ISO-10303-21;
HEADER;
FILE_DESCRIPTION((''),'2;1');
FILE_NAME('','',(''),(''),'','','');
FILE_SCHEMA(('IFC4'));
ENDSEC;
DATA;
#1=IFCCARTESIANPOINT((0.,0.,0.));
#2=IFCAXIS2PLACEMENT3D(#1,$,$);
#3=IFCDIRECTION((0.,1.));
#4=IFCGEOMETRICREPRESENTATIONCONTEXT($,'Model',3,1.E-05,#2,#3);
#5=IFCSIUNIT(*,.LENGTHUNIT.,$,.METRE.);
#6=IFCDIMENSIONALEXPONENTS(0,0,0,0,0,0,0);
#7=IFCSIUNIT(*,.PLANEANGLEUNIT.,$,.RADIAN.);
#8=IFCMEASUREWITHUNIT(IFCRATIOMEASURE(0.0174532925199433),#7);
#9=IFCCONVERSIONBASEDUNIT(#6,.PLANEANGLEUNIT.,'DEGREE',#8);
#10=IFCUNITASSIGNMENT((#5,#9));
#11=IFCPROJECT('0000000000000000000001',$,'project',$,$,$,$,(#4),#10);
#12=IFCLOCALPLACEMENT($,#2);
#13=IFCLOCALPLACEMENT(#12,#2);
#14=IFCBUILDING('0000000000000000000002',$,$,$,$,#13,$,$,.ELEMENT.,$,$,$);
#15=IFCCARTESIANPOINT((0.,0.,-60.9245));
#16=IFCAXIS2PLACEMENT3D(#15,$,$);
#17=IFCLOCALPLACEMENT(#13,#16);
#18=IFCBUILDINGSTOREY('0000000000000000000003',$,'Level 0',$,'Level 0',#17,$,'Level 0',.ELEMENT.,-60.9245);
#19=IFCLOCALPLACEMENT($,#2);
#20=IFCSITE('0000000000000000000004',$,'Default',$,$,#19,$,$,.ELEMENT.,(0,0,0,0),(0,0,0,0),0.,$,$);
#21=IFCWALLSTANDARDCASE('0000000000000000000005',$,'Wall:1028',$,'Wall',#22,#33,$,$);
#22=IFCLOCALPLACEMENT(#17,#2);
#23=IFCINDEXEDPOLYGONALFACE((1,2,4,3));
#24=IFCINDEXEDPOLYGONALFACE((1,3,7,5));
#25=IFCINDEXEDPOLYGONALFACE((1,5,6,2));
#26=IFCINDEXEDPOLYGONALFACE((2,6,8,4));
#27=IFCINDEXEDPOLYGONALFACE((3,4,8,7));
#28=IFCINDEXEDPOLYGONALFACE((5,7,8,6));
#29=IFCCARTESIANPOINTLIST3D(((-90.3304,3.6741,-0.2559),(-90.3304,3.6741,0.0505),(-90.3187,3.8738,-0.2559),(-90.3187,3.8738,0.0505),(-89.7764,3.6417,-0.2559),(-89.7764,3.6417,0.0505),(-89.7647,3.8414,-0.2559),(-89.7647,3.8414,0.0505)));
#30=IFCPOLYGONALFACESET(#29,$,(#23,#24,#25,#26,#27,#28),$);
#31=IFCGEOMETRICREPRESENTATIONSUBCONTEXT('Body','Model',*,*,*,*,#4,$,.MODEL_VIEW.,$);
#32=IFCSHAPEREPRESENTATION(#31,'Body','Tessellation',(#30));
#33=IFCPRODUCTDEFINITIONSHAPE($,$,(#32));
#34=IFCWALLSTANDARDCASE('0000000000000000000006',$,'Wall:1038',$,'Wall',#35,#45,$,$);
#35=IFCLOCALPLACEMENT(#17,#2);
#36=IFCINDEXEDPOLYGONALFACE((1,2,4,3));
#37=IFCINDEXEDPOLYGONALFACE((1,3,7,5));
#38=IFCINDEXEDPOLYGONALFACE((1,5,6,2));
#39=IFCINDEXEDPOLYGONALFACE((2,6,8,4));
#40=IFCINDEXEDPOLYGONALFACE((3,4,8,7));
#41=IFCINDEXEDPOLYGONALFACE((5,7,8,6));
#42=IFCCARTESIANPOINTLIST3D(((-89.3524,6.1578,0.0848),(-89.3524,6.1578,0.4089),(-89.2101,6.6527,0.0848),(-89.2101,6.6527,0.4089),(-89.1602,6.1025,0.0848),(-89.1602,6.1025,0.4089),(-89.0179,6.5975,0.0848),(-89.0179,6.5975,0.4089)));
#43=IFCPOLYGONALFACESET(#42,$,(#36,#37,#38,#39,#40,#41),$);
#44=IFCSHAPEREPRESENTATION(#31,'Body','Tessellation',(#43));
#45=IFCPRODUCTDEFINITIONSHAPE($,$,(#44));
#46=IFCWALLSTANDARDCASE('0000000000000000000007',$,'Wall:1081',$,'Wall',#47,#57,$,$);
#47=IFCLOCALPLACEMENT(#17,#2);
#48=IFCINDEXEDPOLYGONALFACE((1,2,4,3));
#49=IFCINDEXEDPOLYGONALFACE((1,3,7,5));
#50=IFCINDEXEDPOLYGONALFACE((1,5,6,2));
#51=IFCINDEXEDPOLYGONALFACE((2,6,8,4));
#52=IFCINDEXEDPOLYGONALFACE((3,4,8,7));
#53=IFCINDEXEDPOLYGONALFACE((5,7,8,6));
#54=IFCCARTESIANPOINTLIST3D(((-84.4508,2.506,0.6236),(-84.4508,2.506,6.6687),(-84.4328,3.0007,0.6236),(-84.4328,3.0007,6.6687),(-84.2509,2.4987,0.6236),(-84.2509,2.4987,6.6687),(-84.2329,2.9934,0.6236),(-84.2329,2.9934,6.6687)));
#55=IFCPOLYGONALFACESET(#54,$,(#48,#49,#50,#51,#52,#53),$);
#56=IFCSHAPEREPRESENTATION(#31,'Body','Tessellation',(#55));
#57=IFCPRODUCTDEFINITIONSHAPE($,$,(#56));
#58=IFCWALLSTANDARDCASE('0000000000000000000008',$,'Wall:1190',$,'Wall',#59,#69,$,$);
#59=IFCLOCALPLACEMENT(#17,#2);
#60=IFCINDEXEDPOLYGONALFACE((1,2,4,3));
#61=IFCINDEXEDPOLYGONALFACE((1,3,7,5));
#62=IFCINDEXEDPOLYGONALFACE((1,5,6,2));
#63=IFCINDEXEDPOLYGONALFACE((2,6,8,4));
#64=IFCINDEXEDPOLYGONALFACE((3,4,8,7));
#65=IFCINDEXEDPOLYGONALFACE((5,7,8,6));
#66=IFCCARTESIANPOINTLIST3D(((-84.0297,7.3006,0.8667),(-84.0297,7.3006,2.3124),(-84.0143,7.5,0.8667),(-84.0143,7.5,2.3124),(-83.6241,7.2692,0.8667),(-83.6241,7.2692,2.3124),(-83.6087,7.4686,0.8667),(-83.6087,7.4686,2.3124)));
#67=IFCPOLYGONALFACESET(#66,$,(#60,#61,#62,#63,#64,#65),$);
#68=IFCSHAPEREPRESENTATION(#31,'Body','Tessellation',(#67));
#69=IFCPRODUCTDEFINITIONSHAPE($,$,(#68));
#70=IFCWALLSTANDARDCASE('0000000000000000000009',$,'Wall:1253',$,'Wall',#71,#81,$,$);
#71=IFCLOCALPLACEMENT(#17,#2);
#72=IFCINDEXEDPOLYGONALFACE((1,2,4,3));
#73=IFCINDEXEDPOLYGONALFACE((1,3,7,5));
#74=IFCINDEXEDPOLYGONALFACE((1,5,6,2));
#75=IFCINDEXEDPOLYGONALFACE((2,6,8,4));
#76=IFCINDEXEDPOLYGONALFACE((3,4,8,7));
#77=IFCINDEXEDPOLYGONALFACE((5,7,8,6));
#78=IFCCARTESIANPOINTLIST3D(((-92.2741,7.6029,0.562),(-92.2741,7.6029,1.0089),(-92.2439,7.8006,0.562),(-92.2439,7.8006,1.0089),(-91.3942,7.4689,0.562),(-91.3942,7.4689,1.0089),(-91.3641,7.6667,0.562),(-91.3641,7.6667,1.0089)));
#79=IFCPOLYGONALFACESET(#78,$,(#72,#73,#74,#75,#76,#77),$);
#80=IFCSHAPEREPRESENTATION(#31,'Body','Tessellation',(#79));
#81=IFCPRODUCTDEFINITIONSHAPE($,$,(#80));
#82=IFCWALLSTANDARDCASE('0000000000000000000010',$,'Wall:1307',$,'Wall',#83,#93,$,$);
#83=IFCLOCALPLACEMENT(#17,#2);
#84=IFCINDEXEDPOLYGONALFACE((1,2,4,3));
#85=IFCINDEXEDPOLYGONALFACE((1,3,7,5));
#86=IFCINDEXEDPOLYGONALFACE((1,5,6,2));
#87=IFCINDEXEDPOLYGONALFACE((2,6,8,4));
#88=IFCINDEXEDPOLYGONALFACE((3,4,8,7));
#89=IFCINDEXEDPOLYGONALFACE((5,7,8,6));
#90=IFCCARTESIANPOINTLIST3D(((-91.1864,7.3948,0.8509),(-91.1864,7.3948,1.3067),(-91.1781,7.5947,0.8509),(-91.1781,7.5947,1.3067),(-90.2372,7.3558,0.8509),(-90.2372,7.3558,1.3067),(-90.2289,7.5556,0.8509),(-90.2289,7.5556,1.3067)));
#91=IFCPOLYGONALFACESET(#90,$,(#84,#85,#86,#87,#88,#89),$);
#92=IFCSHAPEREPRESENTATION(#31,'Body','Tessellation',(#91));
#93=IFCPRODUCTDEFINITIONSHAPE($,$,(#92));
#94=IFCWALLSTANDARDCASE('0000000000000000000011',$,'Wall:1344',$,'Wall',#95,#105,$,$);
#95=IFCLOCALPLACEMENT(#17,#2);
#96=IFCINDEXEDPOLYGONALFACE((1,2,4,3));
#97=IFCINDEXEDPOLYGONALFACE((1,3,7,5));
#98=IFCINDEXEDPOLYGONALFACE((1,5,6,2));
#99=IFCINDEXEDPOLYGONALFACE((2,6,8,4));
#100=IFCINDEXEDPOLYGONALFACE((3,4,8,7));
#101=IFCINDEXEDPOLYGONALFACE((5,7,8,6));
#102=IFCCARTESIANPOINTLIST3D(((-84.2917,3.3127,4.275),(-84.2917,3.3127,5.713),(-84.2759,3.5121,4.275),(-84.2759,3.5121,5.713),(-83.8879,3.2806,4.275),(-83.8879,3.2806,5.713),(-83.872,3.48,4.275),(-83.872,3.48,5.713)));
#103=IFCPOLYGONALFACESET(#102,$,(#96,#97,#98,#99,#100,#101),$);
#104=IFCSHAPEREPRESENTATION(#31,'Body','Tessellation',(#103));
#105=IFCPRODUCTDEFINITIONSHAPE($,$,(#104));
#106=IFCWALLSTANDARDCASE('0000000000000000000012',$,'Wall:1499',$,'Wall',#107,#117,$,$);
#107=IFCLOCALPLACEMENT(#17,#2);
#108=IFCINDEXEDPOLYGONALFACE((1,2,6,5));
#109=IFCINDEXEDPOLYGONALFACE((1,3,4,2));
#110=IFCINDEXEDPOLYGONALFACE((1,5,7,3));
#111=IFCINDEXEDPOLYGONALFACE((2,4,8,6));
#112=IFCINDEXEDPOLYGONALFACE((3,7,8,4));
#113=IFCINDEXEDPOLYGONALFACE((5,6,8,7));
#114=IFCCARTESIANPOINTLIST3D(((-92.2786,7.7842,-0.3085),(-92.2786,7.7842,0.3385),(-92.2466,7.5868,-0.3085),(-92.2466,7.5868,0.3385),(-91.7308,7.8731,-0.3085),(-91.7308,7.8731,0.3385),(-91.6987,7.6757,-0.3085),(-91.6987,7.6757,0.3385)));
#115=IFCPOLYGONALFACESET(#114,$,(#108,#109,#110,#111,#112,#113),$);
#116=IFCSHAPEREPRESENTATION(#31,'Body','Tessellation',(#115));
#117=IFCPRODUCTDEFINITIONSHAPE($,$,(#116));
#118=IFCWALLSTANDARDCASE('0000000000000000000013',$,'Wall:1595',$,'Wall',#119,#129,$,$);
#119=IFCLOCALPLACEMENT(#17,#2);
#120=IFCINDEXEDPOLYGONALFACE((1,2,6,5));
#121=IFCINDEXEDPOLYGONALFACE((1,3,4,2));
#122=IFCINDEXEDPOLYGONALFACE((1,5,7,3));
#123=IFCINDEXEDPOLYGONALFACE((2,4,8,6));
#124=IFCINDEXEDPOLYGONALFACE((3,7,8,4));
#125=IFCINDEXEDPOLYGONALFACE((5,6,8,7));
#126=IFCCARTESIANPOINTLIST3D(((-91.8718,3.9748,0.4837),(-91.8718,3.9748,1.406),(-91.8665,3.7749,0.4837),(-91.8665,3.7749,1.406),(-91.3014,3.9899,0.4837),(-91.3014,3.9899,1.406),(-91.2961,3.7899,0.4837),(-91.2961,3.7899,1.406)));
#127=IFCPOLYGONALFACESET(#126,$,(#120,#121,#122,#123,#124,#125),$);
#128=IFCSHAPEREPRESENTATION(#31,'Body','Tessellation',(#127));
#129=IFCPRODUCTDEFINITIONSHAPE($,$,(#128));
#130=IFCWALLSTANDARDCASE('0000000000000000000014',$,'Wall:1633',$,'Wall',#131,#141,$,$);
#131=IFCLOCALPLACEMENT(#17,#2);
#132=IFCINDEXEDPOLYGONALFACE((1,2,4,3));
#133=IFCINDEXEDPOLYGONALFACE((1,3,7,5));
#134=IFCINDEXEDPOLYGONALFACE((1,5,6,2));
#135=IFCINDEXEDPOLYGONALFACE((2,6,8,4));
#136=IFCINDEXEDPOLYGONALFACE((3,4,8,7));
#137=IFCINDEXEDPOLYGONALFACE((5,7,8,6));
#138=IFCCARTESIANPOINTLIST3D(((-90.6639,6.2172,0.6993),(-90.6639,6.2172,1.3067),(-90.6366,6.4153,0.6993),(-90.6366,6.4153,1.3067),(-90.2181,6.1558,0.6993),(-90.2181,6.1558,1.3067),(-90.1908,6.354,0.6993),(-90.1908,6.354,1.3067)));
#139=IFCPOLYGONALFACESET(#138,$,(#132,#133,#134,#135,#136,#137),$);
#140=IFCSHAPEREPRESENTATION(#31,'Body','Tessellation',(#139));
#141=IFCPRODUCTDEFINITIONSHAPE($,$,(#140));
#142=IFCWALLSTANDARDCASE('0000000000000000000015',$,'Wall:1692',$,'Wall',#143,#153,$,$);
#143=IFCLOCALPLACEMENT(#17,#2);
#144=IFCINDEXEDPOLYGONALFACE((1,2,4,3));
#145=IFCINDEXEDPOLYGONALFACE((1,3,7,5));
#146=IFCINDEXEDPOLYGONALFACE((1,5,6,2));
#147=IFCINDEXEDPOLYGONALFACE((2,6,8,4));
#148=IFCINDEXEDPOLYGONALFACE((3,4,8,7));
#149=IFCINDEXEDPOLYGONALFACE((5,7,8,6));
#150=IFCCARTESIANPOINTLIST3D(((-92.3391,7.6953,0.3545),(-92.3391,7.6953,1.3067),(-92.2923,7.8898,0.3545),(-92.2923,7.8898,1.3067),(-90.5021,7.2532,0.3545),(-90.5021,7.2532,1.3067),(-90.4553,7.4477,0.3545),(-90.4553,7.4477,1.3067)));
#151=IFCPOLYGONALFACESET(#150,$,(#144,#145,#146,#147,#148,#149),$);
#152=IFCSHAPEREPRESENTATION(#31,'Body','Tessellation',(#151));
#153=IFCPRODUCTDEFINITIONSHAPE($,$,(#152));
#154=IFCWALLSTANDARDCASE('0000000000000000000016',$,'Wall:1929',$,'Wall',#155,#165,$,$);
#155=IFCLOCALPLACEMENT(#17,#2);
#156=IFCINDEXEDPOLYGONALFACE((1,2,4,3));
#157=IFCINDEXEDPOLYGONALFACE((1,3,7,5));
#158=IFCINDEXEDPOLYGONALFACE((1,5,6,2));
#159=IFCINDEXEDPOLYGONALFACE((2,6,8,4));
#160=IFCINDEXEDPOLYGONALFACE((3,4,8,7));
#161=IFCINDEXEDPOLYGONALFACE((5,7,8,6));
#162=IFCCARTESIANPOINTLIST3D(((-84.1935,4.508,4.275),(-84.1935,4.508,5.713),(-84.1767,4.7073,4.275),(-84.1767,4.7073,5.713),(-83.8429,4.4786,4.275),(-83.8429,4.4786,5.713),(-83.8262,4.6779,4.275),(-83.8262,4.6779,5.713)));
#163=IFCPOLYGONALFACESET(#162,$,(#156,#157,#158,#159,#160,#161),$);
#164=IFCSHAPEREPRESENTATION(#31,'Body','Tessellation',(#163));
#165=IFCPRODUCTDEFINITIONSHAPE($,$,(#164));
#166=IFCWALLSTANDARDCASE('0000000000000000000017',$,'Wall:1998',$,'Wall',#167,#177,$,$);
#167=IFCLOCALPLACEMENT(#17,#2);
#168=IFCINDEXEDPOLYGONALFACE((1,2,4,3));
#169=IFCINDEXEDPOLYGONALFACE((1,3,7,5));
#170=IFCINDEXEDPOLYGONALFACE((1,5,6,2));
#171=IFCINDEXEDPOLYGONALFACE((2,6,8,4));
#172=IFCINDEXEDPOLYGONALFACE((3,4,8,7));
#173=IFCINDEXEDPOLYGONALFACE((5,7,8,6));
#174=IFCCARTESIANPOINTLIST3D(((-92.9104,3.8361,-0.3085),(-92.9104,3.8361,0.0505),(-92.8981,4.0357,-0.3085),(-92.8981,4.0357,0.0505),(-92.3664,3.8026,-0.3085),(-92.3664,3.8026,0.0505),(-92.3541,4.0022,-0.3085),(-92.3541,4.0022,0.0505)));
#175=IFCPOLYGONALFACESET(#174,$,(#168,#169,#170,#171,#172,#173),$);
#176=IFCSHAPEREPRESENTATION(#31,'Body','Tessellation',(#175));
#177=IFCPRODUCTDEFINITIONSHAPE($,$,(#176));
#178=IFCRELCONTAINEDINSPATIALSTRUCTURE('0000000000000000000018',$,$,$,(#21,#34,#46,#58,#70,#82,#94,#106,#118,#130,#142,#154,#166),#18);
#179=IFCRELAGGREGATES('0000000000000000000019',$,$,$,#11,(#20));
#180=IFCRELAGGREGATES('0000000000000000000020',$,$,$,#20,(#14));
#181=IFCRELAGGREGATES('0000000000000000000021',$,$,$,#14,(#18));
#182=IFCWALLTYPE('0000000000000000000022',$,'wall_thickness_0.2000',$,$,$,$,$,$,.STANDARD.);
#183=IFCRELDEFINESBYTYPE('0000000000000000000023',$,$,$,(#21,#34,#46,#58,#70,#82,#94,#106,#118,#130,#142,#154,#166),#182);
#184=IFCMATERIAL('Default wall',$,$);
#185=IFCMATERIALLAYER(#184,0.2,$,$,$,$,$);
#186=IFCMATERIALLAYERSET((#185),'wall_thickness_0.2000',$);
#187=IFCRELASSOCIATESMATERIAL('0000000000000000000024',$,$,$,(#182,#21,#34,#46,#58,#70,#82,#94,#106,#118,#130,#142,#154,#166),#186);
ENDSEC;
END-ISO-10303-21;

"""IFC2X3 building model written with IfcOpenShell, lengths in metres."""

from ifc_helpers import new_model, entity, si_unit, converted_unit, direction, frame, origin, place, context, subcontext, project, spatial, polyline, outline, extrude, material, layer, layer_set, layer_usage, type_object, element, save


model = new_model("IFC2X3")

# Units and contexts
model_context = context("Model", 3, precision=1e-05, world=origin(), true_north=direction((0.0, 1.0)))
body_context = subcontext(model_context, "Body", "Model", "MODEL_VIEW")
ifc_project = project(units=[si_unit("LENGTHUNIT", "METRE"), converted_unit("PLANEANGLEUNIT", "DEGREE", entity("IfcRatioMeasure", 0.0174532925199433), si_unit("PLANEANGLEUNIT", "RADIAN"), dimensions=[0, 0, 0, 0, 0, 0, 0])], contexts=[model_context])

# Site, building, storey
site_placement = place(None, origin())
site = spatial("IfcSite", under=ifc_project, at=site_placement, Name="Default", CompositionType="ELEMENT", RefLatitude=(0, 0, 0, 0), RefLongitude=(0, 0, 0, 0), RefElevation=0.0)
placement_1 = place(None, origin())
building_placement = place(placement_1, origin())
building = spatial("IfcBuilding", under=site, at=building_placement, CompositionType="ELEMENT")
storey_placement = place(building_placement, frame((0.0, 0.0, -60.9245)))
storey = spatial("IfcBuildingStorey", under=building, at=storey_placement, Name="Level 0", ObjectType="Level 0", LongName="Level 0", CompositionType="ELEMENT", Elevation=-60.9245)

# Walls
ifc_material = material(Name="Default wall")
ifc_layer = layer(ifc_material, 0.2)
ifc_layer_set = layer_set([ifc_layer], Name="wall_thickness_0.2000")
ifc_layer_usage = layer_usage(ifc_layer_set, "AXIS2", "POSITIVE", -0.1)
wall_type = type_object("IfcWallType", Name="wall_thickness_0.2000", PredefinedType="STANDARD", material=ifc_layer_set)
placement_2 = place(building_placement, frame((0.0, 0.0, -61.1804)))
wall_1_placement = place(placement_2, frame((-90.3246, 3.774, 0.0), z_axis=(0.0, 0.0, 1.0), x_axis=(0.998296, -0.058347, 0.0)))
element("IfcWallStandardCase", 1, at=wall_1_placement, inside=storey, type_object=wall_type, material=ifc_layer_usage, Name="Wall:1028", ObjectType="Wall", context=body_context, shape_type="SweptSolid", body=[
    extrude(outline(polyline([(0.555, -0.1), (0.555, 0.1), (0.0, 0.1), (0.0, -0.1), (0.555, -0.1)])), origin(), (0.0, 0.0, 1.0), 0.3064),
])
placement_3 = place(building_placement, frame((0.0, 0.0, -60.8397)))
wall_2_placement = place(placement_3, frame((-89.2563, 6.1302, 0.0), z_axis=(0.0, 0.0, 1.0), x_axis=(0.276303, 0.961071, 0.0)))
element("IfcWallStandardCase", 2, at=wall_2_placement, inside=storey, type_object=wall_type, material=ifc_layer_usage, Name="Wall:1038", ObjectType="Wall", context=body_context, shape_type="SweptSolid", body=[
    extrude(outline(polyline([(0.515, -0.1), (0.515, 0.1), (0.0, 0.1), (0.0, -0.1), (0.515, -0.1)])), origin(), (0.0, 0.0, 1.0), 0.3241),
])
placement_4 = place(building_placement, frame((0.0, 0.0, -60.3009)))
wall_3_placement = place(placement_4, frame((-84.3508, 2.5024, 0.0), z_axis=(0.0, 0.0, 1.0), x_axis=(0.036344, 0.999339, 0.0)))
element("IfcWallStandardCase", 3, at=wall_3_placement, inside=storey, type_object=wall_type, material=ifc_layer_usage, Name="Wall:1081", ObjectType="Wall", context=body_context, shape_type="SweptSolid", body=[
    extrude(outline(polyline([(0.495, -0.1), (0.495, 0.1), (0.0, 0.1), (0.0, -0.1), (0.495, -0.1)])), origin(), (0.0, 0.0, 1.0), 6.0451),
])
placement_5 = place(building_placement, frame((0.0, 0.0, -60.0578)))
wall_4_placement = place(placement_5, frame((-83.6164, 7.3689, 0.0), z_axis=(0.0, 0.0, 1.0), x_axis=(-0.997023, 0.077108, 0.0)))
element("IfcWallStandardCase", 4, at=wall_4_placement, inside=storey, type_object=wall_type, material=ifc_layer_usage, Name="Wall:1190", ObjectType="Wall", context=body_context, shape_type="SweptSolid", body=[
    extrude(outline(polyline([(0.4068, -0.1), (0.4068, 0.1), (0.0, 0.1), (0.0, -0.1), (0.4068, -0.1)])), origin(), (0.0, 0.0, 1.0), 1.4457),
])
placement_6 = place(building_placement, frame((0.0, 0.0, -60.3625)))
wall_5_placement = place(placement_6, frame((-92.259, 7.7018, 0.0), z_axis=(0.0, 0.0, 1.0), x_axis=(0.988603, -0.150546, 0.0)))
element("IfcWallStandardCase", 5, at=wall_5_placement, inside=storey, type_object=wall_type, material=ifc_layer_usage, Name="Wall:1253", ObjectType="Wall", context=body_context, shape_type="SweptSolid", body=[
    extrude(outline(polyline([(0.89, -0.1), (0.89, 0.1), (0.0, 0.1), (0.0, -0.1), (0.89, -0.1)])), origin(), (0.0, 0.0, 1.0), 0.447),
])
placement_7 = place(building_placement, frame((0.0, 0.0, -60.0736)))
wall_6_placement = place(placement_7, frame((-91.1822, 7.4948, 0.0), z_axis=(0.0, 0.0, 1.0), x_axis=(0.999156, -0.041086, 0.0)))
element("IfcWallStandardCase", 6, at=wall_6_placement, inside=storey, type_object=wall_type, material=ifc_layer_usage, Name="Wall:1307", ObjectType="Wall", context=body_context, shape_type="SweptSolid", body=[
    extrude(outline(polyline([(0.95, -0.1), (0.95, 0.1), (0.0, 0.1), (0.0, -0.1), (0.95, -0.1)])), origin(), (0.0, 0.0, 1.0), 0.4559),
])
placement_8 = place(building_placement, frame((0.0, 0.0, -56.6495)))
wall_7_placement = place(placement_8, frame((-83.88, 3.3803, 0.0), z_axis=(0.0, 0.0, 1.0), x_axis=(-0.996847, 0.079351, 0.0)))
element("IfcWallStandardCase", 7, at=wall_7_placement, inside=storey, type_object=wall_type, material=ifc_layer_usage, Name="Wall:1344", ObjectType="Wall", context=body_context, shape_type="SweptSolid", body=[
    extrude(outline(polyline([(0.4051, -0.1), (0.4051, 0.1), (0.0, 0.1), (0.0, -0.1), (0.4051, -0.1)])), origin(), (0.0, 0.0, 1.0), 1.438),
])
placement_9 = place(building_placement, frame((0.0, 0.0, -61.233)))
wall_8_placement = place(placement_9, frame((-91.7148, 7.7744, 0.0), z_axis=(0.0, 0.0, 1.0), x_axis=(-0.987095, -0.160136, 0.0)))
element("IfcWallStandardCase", 8, at=wall_8_placement, inside=storey, type_object=wall_type, material=ifc_layer_usage, Name="Wall:1499", ObjectType="Wall", context=body_context, shape_type="SweptSolid", body=[
    extrude(outline(polyline([(0.555, -0.1), (0.555, 0.1), (0.0, 0.1), (0.0, -0.1), (0.555, -0.1)])), origin(), (0.0, 0.0, 1.0), 0.647),
])
placement_10 = place(building_placement, frame((0.0, 0.0, -60.4408)))
wall_9_placement = place(placement_10, frame((-91.2988, 3.8899, 0.0), z_axis=(0.0, 0.0, 1.0), x_axis=(-0.999653, -0.026343, 0.0)))
element("IfcWallStandardCase", 9, at=wall_9_placement, inside=storey, type_object=wall_type, material=ifc_layer_usage, Name="Wall:1595", ObjectType="Wall", context=body_context, shape_type="SweptSolid", body=[
    extrude(outline(polyline([(0.5706, -0.1), (0.5706, 0.1), (0.0, 0.1), (0.0, -0.1), (0.5706, -0.1)])), origin(), (0.0, 0.0, 1.0), 0.9223),
])
placement_11 = place(building_placement, frame((0.0, 0.0, -60.2252)))
wall_10_placement = place(placement_11, frame((-90.2045, 6.2549, 0.0), z_axis=(0.0, 0.0, 1.0), x_axis=(-0.99067, 0.136283, 0.0)))
element("IfcWallStandardCase", 10, at=wall_10_placement, inside=storey, type_object=wall_type, material=ifc_layer_usage, Name="Wall:1633", ObjectType="Wall", context=body_context, shape_type="SweptSolid", body=[
    extrude(outline(polyline([(0.45, -0.1), (0.45, 0.1), (0.0, 0.1), (0.0, -0.1), (0.45, -0.1)])), origin(), (0.0, 0.0, 1.0), 0.6075),
])
placement_12 = place(building_placement, frame((0.0, 0.0, -60.57)))
wall_11_placement = place(placement_12, frame((-92.3157, 7.7926, 0.0), z_axis=(0.0, 0.0, 1.0), x_axis=(0.972238, -0.233996, 0.0)))
element("IfcWallStandardCase", 11, at=wall_11_placement, inside=storey, type_object=wall_type, material=ifc_layer_usage, Name="Wall:1692", ObjectType="Wall", context=body_context, shape_type="SweptSolid", body=[
    extrude(outline(polyline([(1.8895, -0.1), (1.8895, 0.1), (0.0, 0.1), (0.0, -0.1), (1.8895, -0.1)])), origin(), (0.0, 0.0, 1.0), 0.9522),
])
placement_13 = place(building_placement, frame((0.0, 0.0, -56.6495)))
wall_12_placement = place(placement_13, frame((-83.8346, 4.5782, 0.0), z_axis=(0.0, 0.0, 1.0), x_axis=(-0.996495, 0.083647, 0.0)))
element("IfcWallStandardCase", 12, at=wall_12_placement, inside=storey, type_object=wall_type, material=ifc_layer_usage, Name="Wall:1929", ObjectType="Wall", context=body_context, shape_type="SweptSolid", body=[
    extrude(outline(polyline([(0.3518, -0.1), (0.3518, 0.1), (0.0, 0.1), (0.0, -0.1), (0.3518, -0.1)])), origin(), (0.0, 0.0, 1.0), 1.438),
])
placement_14 = place(building_placement, frame((0.0, 0.0, -61.233)))
wall_13_placement = place(placement_14, frame((-92.3603, 3.9024, 0.0), z_axis=(0.0, 0.0, 1.0), x_axis=(-0.998106, 0.061511, 0.0)))
element("IfcWallStandardCase", 13, at=wall_13_placement, inside=storey, type_object=wall_type, material=ifc_layer_usage, Name="Wall:1998", ObjectType="Wall", context=body_context, shape_type="SweptSolid", body=[
    extrude(outline(polyline([(0.545, -0.1), (0.545, 0.1), (0.0, 0.1), (0.0, -0.1), (0.545, -0.1)])), origin(), (0.0, 0.0, 1.0), 0.359),
])

save(model, "model.ifc")
